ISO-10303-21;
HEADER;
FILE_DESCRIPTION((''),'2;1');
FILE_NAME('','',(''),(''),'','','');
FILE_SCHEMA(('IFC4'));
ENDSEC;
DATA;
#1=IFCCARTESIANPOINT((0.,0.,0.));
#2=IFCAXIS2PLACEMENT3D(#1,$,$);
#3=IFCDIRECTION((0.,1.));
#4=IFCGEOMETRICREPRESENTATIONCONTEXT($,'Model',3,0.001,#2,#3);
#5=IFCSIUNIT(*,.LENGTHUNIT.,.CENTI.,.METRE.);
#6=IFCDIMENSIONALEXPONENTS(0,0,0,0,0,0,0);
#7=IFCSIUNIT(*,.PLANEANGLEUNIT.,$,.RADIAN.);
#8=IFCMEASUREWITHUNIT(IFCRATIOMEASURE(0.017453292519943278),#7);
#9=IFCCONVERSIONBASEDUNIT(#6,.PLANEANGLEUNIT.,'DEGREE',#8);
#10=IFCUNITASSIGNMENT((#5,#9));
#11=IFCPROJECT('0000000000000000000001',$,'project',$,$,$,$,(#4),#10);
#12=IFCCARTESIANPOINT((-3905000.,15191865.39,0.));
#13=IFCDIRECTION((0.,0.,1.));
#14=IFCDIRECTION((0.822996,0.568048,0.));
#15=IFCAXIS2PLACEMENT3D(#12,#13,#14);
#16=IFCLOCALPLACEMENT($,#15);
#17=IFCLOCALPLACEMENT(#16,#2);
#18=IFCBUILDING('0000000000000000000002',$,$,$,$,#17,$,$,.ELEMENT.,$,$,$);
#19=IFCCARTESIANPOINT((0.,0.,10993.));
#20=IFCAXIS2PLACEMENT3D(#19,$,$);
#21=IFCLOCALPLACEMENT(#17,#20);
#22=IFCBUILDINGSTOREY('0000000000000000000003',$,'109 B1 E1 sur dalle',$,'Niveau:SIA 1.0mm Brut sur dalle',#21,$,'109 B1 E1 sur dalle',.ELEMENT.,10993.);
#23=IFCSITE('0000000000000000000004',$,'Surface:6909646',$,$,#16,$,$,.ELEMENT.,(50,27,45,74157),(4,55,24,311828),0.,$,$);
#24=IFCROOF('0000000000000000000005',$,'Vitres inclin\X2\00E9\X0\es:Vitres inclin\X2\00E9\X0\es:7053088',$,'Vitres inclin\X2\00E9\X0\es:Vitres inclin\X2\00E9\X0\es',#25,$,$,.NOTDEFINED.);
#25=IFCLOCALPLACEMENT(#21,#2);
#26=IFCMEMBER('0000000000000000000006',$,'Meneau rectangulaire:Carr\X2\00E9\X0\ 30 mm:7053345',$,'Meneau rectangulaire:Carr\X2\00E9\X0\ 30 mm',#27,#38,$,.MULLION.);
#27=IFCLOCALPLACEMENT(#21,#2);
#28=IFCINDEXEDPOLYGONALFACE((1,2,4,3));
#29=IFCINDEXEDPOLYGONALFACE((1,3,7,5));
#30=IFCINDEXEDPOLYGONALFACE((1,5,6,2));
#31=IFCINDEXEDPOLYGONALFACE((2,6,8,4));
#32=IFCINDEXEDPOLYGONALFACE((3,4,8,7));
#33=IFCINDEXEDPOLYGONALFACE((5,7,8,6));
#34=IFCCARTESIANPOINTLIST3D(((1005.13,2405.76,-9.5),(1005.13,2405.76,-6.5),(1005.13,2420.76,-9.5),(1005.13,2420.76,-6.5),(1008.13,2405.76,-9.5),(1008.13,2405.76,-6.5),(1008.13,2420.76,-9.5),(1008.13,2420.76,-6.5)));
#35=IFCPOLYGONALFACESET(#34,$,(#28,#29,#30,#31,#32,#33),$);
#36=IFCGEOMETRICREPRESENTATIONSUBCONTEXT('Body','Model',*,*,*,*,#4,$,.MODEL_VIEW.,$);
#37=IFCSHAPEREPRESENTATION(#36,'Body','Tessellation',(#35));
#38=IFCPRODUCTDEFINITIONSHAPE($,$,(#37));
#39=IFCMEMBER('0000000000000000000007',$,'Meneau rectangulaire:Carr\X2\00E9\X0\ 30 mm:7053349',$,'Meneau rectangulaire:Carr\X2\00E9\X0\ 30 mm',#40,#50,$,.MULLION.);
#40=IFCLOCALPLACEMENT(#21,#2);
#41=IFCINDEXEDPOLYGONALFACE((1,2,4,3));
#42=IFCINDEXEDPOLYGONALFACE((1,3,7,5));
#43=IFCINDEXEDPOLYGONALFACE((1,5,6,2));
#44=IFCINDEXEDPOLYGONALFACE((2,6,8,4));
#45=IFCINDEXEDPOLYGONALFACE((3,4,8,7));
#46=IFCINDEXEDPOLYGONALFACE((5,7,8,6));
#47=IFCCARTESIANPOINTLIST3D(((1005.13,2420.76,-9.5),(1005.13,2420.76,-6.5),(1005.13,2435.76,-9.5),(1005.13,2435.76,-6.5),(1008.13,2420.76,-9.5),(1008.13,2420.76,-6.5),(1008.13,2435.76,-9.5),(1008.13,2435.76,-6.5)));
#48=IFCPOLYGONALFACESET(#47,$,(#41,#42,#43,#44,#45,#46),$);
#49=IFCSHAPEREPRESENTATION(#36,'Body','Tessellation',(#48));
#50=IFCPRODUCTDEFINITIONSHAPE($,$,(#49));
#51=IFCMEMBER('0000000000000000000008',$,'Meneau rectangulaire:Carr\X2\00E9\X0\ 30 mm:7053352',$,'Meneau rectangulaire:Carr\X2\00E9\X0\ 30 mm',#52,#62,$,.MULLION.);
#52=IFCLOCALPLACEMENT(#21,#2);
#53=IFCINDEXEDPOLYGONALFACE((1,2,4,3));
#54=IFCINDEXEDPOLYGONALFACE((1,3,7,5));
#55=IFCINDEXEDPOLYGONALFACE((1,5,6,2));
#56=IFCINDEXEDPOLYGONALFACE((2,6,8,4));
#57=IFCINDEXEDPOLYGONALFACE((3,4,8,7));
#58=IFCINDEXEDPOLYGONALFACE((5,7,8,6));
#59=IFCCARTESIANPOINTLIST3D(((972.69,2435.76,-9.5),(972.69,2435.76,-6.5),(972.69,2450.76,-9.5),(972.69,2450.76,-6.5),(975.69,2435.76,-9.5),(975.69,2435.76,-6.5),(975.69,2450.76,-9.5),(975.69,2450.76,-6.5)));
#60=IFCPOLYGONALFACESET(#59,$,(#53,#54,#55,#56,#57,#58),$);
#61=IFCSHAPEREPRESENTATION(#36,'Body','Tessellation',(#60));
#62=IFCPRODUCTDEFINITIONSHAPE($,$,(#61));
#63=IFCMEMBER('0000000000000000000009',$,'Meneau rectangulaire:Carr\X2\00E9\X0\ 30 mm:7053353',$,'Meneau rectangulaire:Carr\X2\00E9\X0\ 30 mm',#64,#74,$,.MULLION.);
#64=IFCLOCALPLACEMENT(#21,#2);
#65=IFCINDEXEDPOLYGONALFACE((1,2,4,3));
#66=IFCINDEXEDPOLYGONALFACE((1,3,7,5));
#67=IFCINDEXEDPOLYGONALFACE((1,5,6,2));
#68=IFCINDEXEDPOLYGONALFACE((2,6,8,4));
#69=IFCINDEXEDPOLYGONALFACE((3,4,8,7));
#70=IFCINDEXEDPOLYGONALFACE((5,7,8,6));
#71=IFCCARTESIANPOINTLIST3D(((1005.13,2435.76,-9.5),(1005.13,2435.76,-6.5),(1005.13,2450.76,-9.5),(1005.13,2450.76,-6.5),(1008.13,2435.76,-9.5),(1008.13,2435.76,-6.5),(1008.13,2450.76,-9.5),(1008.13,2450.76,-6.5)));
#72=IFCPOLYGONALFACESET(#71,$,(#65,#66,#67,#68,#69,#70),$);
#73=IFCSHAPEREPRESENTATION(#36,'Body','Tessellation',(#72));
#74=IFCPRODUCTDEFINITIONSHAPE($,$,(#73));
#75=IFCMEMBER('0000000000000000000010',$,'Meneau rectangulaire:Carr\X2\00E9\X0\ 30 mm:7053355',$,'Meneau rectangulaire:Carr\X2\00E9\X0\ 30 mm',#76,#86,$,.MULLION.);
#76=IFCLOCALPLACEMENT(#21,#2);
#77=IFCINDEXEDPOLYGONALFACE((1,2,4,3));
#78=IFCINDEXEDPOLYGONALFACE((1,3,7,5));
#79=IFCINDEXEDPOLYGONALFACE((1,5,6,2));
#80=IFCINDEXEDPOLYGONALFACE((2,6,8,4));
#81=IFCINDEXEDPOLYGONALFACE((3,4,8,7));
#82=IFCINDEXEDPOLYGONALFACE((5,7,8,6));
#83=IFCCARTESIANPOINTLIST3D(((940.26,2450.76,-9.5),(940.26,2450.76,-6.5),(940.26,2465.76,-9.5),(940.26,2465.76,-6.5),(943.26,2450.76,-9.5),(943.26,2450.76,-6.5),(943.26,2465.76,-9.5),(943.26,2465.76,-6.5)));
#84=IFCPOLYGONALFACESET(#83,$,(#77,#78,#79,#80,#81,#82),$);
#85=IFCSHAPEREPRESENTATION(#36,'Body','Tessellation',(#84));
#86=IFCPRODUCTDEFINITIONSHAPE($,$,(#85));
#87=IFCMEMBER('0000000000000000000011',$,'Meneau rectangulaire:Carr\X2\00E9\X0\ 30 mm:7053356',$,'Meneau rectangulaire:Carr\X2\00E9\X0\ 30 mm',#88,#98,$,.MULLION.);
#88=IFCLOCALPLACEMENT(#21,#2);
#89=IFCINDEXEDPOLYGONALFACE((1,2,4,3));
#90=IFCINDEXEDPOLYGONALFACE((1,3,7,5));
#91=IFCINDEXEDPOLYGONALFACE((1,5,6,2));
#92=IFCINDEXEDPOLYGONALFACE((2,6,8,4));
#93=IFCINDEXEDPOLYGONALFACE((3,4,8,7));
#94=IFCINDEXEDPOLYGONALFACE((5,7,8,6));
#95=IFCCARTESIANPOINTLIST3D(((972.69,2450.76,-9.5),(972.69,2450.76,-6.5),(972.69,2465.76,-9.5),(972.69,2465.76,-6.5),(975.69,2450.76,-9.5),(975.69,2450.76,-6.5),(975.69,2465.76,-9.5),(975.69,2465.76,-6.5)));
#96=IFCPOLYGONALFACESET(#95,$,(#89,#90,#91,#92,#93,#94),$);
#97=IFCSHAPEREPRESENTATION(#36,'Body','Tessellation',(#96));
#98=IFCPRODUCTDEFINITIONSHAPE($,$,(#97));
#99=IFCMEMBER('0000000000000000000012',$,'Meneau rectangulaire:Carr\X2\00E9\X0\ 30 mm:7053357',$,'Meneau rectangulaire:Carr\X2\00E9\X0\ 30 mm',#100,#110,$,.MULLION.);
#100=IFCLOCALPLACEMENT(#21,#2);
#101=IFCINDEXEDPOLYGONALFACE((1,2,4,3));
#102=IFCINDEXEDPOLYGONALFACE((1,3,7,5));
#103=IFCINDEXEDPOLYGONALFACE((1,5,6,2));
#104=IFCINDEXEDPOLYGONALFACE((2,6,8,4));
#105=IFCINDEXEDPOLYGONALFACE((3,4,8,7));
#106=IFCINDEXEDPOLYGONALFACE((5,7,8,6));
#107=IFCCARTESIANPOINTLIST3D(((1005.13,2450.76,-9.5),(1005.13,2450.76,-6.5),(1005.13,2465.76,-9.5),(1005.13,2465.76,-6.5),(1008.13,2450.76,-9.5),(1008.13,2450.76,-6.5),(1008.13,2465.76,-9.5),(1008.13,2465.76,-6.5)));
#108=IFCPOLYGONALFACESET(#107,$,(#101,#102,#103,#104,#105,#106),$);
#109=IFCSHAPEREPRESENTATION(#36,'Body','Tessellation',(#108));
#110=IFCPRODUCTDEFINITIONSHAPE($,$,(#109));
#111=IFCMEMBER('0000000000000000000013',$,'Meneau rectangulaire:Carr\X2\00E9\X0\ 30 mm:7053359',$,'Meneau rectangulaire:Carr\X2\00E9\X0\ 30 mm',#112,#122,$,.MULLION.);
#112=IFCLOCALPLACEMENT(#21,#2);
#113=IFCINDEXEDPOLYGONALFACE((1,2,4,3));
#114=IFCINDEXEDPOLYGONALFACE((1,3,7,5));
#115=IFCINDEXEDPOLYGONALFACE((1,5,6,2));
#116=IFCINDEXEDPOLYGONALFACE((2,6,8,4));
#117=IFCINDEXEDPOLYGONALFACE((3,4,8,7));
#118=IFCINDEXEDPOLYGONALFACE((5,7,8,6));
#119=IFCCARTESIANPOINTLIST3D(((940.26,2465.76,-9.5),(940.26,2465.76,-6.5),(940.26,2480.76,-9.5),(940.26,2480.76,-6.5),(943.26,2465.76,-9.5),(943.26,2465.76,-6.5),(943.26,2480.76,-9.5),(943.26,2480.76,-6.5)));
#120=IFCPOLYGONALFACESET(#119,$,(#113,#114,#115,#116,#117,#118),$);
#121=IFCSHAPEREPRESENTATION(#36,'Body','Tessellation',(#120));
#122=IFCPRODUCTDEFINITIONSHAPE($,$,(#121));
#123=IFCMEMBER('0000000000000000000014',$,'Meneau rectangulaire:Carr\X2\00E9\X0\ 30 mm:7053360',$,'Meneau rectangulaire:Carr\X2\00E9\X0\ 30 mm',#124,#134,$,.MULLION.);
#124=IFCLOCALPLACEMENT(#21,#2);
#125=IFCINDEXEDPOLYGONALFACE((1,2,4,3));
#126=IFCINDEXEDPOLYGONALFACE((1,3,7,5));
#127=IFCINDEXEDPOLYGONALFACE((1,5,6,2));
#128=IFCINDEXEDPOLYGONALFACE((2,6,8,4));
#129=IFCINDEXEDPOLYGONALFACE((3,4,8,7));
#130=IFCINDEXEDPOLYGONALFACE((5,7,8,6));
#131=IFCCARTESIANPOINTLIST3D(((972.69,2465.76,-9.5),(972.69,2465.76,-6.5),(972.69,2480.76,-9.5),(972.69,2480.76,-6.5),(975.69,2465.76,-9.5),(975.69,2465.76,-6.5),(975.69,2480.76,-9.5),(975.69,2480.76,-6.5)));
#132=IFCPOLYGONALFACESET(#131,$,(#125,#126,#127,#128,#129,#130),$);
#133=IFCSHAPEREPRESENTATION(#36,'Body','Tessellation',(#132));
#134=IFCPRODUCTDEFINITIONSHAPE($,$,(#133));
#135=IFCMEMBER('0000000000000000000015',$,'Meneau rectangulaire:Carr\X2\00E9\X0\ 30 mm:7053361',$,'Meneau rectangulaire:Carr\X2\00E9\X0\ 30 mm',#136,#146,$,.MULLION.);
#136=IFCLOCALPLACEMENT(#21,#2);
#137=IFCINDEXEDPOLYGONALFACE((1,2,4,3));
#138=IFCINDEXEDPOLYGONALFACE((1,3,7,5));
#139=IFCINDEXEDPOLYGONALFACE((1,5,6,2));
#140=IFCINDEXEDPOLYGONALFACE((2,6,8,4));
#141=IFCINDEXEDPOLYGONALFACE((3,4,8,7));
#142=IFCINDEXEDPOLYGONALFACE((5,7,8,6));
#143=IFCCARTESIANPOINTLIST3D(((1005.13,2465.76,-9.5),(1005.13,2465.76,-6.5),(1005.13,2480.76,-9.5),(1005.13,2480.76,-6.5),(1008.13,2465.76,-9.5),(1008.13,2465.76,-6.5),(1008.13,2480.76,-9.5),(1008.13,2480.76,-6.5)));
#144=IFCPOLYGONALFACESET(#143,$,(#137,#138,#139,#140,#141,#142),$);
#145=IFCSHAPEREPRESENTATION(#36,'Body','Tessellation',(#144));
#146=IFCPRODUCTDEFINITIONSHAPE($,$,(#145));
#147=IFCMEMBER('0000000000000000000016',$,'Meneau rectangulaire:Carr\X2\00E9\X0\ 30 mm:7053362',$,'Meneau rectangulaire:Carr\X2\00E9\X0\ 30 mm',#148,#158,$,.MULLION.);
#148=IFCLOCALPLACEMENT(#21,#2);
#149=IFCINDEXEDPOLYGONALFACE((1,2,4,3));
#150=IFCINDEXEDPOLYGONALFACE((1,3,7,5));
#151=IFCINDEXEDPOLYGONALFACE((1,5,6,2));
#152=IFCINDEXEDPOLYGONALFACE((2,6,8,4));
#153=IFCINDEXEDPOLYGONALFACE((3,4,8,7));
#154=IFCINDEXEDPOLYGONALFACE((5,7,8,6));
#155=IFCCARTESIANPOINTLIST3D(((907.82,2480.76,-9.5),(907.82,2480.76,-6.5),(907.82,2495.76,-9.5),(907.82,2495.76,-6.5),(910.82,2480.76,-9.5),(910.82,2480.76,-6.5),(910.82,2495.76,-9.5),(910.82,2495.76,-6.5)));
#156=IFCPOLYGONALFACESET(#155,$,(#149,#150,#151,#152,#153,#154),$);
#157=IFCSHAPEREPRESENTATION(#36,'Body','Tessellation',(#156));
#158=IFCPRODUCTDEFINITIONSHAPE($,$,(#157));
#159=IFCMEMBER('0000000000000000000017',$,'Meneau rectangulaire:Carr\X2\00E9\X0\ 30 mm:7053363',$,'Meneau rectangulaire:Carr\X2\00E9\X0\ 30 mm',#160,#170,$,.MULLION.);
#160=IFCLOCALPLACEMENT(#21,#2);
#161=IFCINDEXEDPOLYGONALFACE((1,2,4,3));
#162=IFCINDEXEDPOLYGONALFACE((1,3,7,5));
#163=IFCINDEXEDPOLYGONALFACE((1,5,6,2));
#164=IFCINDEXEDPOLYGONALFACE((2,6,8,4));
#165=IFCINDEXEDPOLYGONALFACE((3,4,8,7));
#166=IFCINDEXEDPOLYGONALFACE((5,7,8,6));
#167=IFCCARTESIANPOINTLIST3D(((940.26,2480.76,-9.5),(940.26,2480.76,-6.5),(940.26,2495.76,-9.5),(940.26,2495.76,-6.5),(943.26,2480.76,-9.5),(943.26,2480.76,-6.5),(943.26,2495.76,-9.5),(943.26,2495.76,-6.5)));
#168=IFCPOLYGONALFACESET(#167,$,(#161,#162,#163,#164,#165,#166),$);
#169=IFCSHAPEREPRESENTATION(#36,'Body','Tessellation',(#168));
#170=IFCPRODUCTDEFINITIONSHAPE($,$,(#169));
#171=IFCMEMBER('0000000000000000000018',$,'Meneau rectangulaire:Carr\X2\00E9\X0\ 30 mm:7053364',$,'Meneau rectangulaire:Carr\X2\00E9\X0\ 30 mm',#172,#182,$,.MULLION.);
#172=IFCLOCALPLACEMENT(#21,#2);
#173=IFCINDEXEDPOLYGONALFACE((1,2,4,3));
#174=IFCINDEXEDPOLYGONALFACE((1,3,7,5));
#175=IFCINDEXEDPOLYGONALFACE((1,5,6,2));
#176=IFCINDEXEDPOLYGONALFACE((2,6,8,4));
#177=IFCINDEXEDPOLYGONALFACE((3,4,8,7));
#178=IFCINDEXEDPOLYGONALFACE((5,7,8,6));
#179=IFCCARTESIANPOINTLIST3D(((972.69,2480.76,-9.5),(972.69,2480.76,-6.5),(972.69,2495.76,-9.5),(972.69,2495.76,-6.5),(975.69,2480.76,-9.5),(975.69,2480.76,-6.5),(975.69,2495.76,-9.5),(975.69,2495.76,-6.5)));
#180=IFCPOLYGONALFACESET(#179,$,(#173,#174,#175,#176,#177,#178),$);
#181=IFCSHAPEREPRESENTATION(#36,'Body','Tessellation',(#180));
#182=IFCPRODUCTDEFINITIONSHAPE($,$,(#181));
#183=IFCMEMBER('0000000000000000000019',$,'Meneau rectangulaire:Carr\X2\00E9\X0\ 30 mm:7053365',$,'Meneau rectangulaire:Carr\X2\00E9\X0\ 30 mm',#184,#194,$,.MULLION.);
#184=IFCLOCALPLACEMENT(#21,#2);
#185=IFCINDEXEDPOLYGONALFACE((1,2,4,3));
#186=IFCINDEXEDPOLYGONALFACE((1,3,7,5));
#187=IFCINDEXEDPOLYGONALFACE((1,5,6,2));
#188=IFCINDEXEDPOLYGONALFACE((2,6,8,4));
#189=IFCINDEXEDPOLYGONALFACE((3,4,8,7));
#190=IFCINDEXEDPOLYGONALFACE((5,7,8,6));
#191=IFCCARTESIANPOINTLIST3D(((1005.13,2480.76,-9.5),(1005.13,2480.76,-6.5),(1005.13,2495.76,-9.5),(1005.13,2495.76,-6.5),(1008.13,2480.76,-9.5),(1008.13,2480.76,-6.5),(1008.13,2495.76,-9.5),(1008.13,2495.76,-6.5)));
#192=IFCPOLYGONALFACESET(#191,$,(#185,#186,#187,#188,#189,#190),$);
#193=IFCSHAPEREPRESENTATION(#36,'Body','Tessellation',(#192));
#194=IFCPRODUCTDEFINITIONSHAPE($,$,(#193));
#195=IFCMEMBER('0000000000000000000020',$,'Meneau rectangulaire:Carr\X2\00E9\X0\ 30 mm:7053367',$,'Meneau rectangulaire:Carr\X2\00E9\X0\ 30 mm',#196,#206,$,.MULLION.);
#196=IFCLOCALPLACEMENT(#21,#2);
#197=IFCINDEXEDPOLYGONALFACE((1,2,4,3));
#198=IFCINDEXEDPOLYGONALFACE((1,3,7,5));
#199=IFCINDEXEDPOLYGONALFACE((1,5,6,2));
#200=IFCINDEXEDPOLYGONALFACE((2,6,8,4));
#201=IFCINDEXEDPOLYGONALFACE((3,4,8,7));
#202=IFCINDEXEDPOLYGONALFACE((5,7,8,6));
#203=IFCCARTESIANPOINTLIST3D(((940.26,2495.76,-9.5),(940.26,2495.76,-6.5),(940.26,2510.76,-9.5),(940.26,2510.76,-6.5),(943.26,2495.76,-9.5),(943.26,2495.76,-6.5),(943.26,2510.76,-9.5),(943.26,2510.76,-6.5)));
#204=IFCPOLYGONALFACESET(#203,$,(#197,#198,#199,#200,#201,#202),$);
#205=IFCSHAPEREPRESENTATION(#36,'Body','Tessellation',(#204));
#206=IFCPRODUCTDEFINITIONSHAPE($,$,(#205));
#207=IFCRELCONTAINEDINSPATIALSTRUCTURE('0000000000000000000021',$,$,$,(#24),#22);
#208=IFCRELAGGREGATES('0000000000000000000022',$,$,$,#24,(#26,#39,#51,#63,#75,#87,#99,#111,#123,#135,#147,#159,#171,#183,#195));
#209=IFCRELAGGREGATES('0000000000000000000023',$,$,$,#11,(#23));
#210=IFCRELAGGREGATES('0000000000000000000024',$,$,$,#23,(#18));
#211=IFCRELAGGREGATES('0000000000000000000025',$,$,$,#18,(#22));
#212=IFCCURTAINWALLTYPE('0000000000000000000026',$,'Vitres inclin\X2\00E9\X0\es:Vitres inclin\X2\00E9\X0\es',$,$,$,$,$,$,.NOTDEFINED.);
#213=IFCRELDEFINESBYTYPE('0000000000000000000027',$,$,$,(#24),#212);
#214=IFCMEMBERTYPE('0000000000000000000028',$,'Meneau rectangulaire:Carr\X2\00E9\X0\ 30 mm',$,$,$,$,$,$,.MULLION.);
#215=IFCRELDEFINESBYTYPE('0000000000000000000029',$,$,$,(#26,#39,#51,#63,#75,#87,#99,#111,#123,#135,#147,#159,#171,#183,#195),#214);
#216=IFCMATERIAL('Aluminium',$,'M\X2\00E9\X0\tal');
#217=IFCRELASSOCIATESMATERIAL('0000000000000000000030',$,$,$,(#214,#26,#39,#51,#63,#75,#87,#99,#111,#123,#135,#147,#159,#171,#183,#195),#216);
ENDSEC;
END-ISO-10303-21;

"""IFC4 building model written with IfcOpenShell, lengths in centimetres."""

from ifc_helpers import new_model, entity, si_unit, converted_unit, direction, frame, origin, place, context, subcontext, project, spatial, indexed_curve, outline, extrude, source, transform, mapped, material, type_object, type_shapes, element, aggregate, save


model = new_model("IFC4")

# Units and contexts
model_context = context("Model", 3, precision=0.001, world=origin(), true_north=direction((0.0, 1.0)))
body_context = subcontext(model_context, "Body", "Model", "MODEL_VIEW")
ifc_project = project(units=[si_unit("LENGTHUNIT", "METRE", prefix="CENTI"), converted_unit("PLANEANGLEUNIT", "DEGREE", entity("IfcRatioMeasure", 0.017453292519943278), si_unit("PLANEANGLEUNIT", "RADIAN"), dimensions=[0, 0, 0, 0, 0, 0, 0])], contexts=[model_context])

# Site, building, storey
site_placement = place(None, frame((-3905000.0, 15191865.39, 0.0), z_axis=(0.0, 0.0, 1.0), x_axis=(0.822996, 0.568048, 0.0)))
site = spatial("IfcSite", under=ifc_project, at=site_placement, Name="Surface:6909646", CompositionType="ELEMENT", RefLatitude=(50, 27, 45, 74157), RefLongitude=(4, 55, 24, 311828), RefElevation=0.0)
building_placement = place(site_placement, origin())
building = spatial("IfcBuilding", under=site, at=building_placement, CompositionType="ELEMENT")
storey_placement = place(building_placement, frame((0.0, 0.0, 10993.0)))
storey = spatial("IfcBuildingStorey", under=building, at=storey_placement, Name="109 B1 E1 sur dalle", ObjectType="Niveau:SIA 1.0mm Brut sur dalle", LongName="109 B1 E1 sur dalle", CompositionType="ELEMENT", Elevation=10993.0)

# Roof, members
curtain_wall_type = type_object("IfcCurtainWallType", Name="Vitres inclinées:Vitres inclinées", PredefinedType="NOTDEFINED")
roof_placement = place(storey_placement, frame((0.0, 0.0, -10993.0)))
roof = element("IfcRoof", 1, at=roof_placement, inside=storey, type_object=curtain_wall_type, Name="Vitres inclinées:Vitres inclinées:7053088", ObjectType="Vitres inclinées:Vitres inclinées", PredefinedType="NOTDEFINED")
ifc_material = material(Name="Aluminium", Category="Métal")
member_type_1 = type_object("IfcMemberType", Name="Meneau rectangulaire:Carré 30 mm", PredefinedType="MULLION", material=ifc_material)
shared_shape_1 = source(origin(), body_context, "Body", "SweptSolid", [
    extrude(outline(indexed_curve([(-1.5, -1.5), (1.5, -1.5), (1.5, 1.5), (-1.5, 1.5), (-1.5, -1.5)], self_intersect=False)), frame((0.0, 0.0, -15.0), z_axis=(0.0, 0.0, 1.0), x_axis=(0.0, -1.0, 0.0)), (0.0, 0.0, 1.0), 15.0),
])
type_shapes(member_type_1, [shared_shape_1])
member_1_placement = place(roof_placement, frame((1006.63, 2420.76, 10985.0), z_axis=(0.0, 1.0, 0.0), x_axis=(1.0, 0.0, 0.0)))
member_1 = element("IfcMember", 2, at=member_1_placement, type_object=member_type_1, material=ifc_material, Name="Meneau rectangulaire:Carré 30 mm:7053345", ObjectType="Meneau rectangulaire:Carré 30 mm", PredefinedType="MULLION", context=body_context, shape_type="MappedRepresentation", body=[
    mapped(shared_shape_1, transform((0.0, 0.0, 0.0), scale=1.0)),
])
member_2_placement = place(roof_placement, frame((1006.63, 2435.76, 10985.0), z_axis=(0.0, 1.0, 0.0), x_axis=(1.0, 0.0, 0.0)))
member_2 = element("IfcMember", 3, at=member_2_placement, type_object=member_type_1, material=ifc_material, Name="Meneau rectangulaire:Carré 30 mm:7053349", ObjectType="Meneau rectangulaire:Carré 30 mm", PredefinedType="MULLION", context=body_context, shape_type="MappedRepresentation", body=[
    mapped(shared_shape_1, transform((0.0, 0.0, 0.0), scale=1.0)),
])
member_3_placement = place(roof_placement, frame((974.19, 2450.76, 10985.0), z_axis=(0.0, 1.0, 0.0), x_axis=(1.0, 0.0, 0.0)))
member_3 = element("IfcMember", 4, at=member_3_placement, type_object=member_type_1, material=ifc_material, Name="Meneau rectangulaire:Carré 30 mm:7053352", ObjectType="Meneau rectangulaire:Carré 30 mm", PredefinedType="MULLION", context=body_context, shape_type="MappedRepresentation", body=[
    mapped(shared_shape_1, transform((0.0, 0.0, 0.0), scale=1.0)),
])
member_4_placement = place(roof_placement, frame((1006.63, 2450.76, 10985.0), z_axis=(0.0, 1.0, 0.0), x_axis=(1.0, 0.0, 0.0)))
member_4 = element("IfcMember", 5, at=member_4_placement, type_object=member_type_1, material=ifc_material, Name="Meneau rectangulaire:Carré 30 mm:7053353", ObjectType="Meneau rectangulaire:Carré 30 mm", PredefinedType="MULLION", context=body_context, shape_type="MappedRepresentation", body=[
    mapped(shared_shape_1, transform((0.0, 0.0, 0.0), scale=1.0)),
])
member_5_placement = place(roof_placement, frame((941.76, 2465.76, 10985.0), z_axis=(0.0, 1.0, 0.0), x_axis=(1.0, 0.0, 0.0)))
member_5 = element("IfcMember", 6, at=member_5_placement, type_object=member_type_1, material=ifc_material, Name="Meneau rectangulaire:Carré 30 mm:7053355", ObjectType="Meneau rectangulaire:Carré 30 mm", PredefinedType="MULLION", context=body_context, shape_type="MappedRepresentation", body=[
    mapped(shared_shape_1, transform((0.0, 0.0, 0.0), scale=1.0)),
])
member_6_placement = place(roof_placement, frame((974.19, 2465.76, 10985.0), z_axis=(0.0, 1.0, 0.0), x_axis=(1.0, 0.0, 0.0)))
member_6 = element("IfcMember", 7, at=member_6_placement, type_object=member_type_1, material=ifc_material, Name="Meneau rectangulaire:Carré 30 mm:7053356", ObjectType="Meneau rectangulaire:Carré 30 mm", PredefinedType="MULLION", context=body_context, shape_type="MappedRepresentation", body=[
    mapped(shared_shape_1, transform((0.0, 0.0, 0.0), scale=1.0)),
])
member_7_placement = place(roof_placement, frame((1006.63, 2465.76, 10985.0), z_axis=(0.0, 1.0, 0.0), x_axis=(1.0, 0.0, 0.0)))
member_7 = element("IfcMember", 8, at=member_7_placement, type_object=member_type_1, material=ifc_material, Name="Meneau rectangulaire:Carré 30 mm:7053357", ObjectType="Meneau rectangulaire:Carré 30 mm", PredefinedType="MULLION", context=body_context, shape_type="MappedRepresentation", body=[
    mapped(shared_shape_1, transform((0.0, 0.0, 0.0), scale=1.0)),
])
member_8_placement = place(roof_placement, frame((941.76, 2480.76, 10985.0), z_axis=(0.0, 1.0, 0.0), x_axis=(1.0, 0.0, 0.0)))
member_8 = element("IfcMember", 9, at=member_8_placement, type_object=member_type_1, material=ifc_material, Name="Meneau rectangulaire:Carré 30 mm:7053359", ObjectType="Meneau rectangulaire:Carré 30 mm", PredefinedType="MULLION", context=body_context, shape_type="MappedRepresentation", body=[
    mapped(shared_shape_1, transform((0.0, 0.0, 0.0), scale=1.0)),
])
member_9_placement = place(roof_placement, frame((974.19, 2480.76, 10985.0), z_axis=(0.0, 1.0, 0.0), x_axis=(1.0, 0.0, 0.0)))
member_9 = element("IfcMember", 10, at=member_9_placement, type_object=member_type_1, material=ifc_material, Name="Meneau rectangulaire:Carré 30 mm:7053360", ObjectType="Meneau rectangulaire:Carré 30 mm", PredefinedType="MULLION", context=body_context, shape_type="MappedRepresentation", body=[
    mapped(shared_shape_1, transform((0.0, 0.0, 0.0), scale=1.0)),
])
member_10_placement = place(roof_placement, frame((1006.63, 2480.76, 10985.0), z_axis=(0.0, 1.0, 0.0), x_axis=(1.0, 0.0, 0.0)))
member_10 = element("IfcMember", 11, at=member_10_placement, type_object=member_type_1, material=ifc_material, Name="Meneau rectangulaire:Carré 30 mm:7053361", ObjectType="Meneau rectangulaire:Carré 30 mm", PredefinedType="MULLION", context=body_context, shape_type="MappedRepresentation", body=[
    mapped(shared_shape_1, transform((0.0, 0.0, 0.0), scale=1.0)),
])
member_11_placement = place(roof_placement, frame((909.32, 2495.76, 10985.0), z_axis=(0.0, 1.0, 0.0), x_axis=(1.0, 0.0, 0.0)))
member_11 = element("IfcMember", 12, at=member_11_placement, type_object=member_type_1, material=ifc_material, Name="Meneau rectangulaire:Carré 30 mm:7053362", ObjectType="Meneau rectangulaire:Carré 30 mm", PredefinedType="MULLION", context=body_context, shape_type="MappedRepresentation", body=[
    mapped(shared_shape_1, transform((0.0, 0.0, 0.0), scale=1.0)),
])
member_12_placement = place(roof_placement, frame((941.76, 2495.76, 10985.0), z_axis=(0.0, 1.0, 0.0), x_axis=(1.0, 0.0, 0.0)))
member_12 = element("IfcMember", 13, at=member_12_placement, type_object=member_type_1, material=ifc_material, Name="Meneau rectangulaire:Carré 30 mm:7053363", ObjectType="Meneau rectangulaire:Carré 30 mm", PredefinedType="MULLION", context=body_context, shape_type="MappedRepresentation", body=[
    mapped(shared_shape_1, transform((0.0, 0.0, 0.0), scale=1.0)),
])
member_13_placement = place(roof_placement, frame((974.19, 2495.76, 10985.0), z_axis=(0.0, 1.0, 0.0), x_axis=(1.0, 0.0, 0.0)))
member_13 = element("IfcMember", 14, at=member_13_placement, type_object=member_type_1, material=ifc_material, Name="Meneau rectangulaire:Carré 30 mm:7053364", ObjectType="Meneau rectangulaire:Carré 30 mm", PredefinedType="MULLION", context=body_context, shape_type="MappedRepresentation", body=[
    mapped(shared_shape_1, transform((0.0, 0.0, 0.0), scale=1.0)),
])
member_14_placement = place(roof_placement, frame((1006.63, 2495.76, 10985.0), z_axis=(0.0, 1.0, 0.0), x_axis=(1.0, 0.0, 0.0)))
member_14 = element("IfcMember", 15, at=member_14_placement, type_object=member_type_1, material=ifc_material, Name="Meneau rectangulaire:Carré 30 mm:7053365", ObjectType="Meneau rectangulaire:Carré 30 mm", PredefinedType="MULLION", context=body_context, shape_type="MappedRepresentation", body=[
    mapped(shared_shape_1, transform((0.0, 0.0, 0.0), scale=1.0)),
])
member_15_placement = place(roof_placement, frame((941.76, 2510.76, 10985.0), z_axis=(0.0, 1.0, 0.0), x_axis=(1.0, 0.0, 0.0)))
member_15 = element("IfcMember", 16, at=member_15_placement, type_object=member_type_1, material=ifc_material, Name="Meneau rectangulaire:Carré 30 mm:7053367", ObjectType="Meneau rectangulaire:Carré 30 mm", PredefinedType="MULLION", context=body_context, shape_type="MappedRepresentation", body=[
    mapped(shared_shape_1, transform((0.0, 0.0, 0.0), scale=1.0)),
])
aggregate(roof, [member_1, member_2, member_3, member_4, member_5, member_6, member_7, member_8, member_9, member_10, member_11, member_12, member_13, member_14, member_15])

save(model, "model.ifc")
